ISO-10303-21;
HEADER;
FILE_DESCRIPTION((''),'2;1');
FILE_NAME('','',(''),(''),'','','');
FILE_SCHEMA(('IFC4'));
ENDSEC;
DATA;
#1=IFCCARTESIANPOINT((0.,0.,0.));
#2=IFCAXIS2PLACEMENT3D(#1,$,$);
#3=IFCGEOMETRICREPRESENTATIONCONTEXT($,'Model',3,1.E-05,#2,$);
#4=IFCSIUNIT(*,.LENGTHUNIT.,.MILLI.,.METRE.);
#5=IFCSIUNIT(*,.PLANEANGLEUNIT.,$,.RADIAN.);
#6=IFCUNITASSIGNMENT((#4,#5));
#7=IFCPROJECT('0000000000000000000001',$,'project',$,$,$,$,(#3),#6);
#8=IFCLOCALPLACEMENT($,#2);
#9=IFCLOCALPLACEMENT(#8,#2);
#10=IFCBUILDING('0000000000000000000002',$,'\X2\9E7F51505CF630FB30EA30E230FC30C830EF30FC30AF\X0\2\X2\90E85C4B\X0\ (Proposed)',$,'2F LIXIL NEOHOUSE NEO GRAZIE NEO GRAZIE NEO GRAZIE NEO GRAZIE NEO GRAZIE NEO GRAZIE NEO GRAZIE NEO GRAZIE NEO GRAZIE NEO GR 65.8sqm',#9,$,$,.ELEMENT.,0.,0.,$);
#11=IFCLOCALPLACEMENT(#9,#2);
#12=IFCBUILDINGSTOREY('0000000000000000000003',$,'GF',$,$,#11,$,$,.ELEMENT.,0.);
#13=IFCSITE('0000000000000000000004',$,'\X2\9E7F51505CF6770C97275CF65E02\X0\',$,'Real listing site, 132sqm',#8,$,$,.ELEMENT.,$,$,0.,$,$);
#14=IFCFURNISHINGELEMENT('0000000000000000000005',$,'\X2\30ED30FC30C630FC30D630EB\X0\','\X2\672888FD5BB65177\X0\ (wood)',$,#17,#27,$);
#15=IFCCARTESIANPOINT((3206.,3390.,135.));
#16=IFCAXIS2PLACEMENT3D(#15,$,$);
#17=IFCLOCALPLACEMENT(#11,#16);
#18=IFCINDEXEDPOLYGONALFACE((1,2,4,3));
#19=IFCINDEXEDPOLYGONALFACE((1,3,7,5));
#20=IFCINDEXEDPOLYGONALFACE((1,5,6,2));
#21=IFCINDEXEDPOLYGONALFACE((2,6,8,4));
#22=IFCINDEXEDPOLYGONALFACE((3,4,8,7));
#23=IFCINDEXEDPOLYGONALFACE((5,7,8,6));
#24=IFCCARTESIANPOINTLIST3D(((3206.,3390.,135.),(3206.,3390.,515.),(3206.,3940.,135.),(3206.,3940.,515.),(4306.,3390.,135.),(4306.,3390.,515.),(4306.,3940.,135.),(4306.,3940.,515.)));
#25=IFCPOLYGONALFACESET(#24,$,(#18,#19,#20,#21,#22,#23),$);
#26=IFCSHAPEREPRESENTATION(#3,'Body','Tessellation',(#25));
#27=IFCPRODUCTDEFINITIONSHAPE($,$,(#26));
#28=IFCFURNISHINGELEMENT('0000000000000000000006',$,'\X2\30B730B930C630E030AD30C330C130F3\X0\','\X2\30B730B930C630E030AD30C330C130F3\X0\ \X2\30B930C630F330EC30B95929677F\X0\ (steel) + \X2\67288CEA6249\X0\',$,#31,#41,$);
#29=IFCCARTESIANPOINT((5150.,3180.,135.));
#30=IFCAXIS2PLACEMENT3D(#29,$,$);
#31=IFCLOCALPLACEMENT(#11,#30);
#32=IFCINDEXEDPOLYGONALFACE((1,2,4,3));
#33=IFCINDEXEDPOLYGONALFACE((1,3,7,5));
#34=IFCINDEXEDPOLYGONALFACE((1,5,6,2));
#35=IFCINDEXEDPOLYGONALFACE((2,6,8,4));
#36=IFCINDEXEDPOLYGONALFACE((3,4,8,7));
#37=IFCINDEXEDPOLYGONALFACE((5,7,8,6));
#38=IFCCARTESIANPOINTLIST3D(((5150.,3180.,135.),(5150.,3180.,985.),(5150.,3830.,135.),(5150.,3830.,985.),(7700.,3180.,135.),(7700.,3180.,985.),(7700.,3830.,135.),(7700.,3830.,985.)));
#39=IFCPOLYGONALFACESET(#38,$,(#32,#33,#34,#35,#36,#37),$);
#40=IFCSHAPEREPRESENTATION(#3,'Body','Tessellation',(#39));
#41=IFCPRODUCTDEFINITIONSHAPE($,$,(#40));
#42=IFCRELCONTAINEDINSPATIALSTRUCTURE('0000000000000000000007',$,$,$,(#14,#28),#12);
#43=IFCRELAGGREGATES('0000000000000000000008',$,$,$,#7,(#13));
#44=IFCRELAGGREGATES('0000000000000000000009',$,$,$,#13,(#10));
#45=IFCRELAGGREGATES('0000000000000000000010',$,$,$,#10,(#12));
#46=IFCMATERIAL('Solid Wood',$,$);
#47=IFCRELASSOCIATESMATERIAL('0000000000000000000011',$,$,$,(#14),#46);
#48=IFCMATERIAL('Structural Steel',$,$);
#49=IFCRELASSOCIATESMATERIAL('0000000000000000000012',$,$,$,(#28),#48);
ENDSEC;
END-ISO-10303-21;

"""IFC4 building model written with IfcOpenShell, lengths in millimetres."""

from ifc_helpers import new_model, si_unit, frame, frame_2d, origin, place, context, project, spatial, rectangle, extrude, material, element, save


model = new_model("IFC4")

# Units and contexts
model_context = context("Model", 3, precision=1e-05, world=origin())
ifc_project = project(units=[si_unit("LENGTHUNIT", "METRE", prefix="MILLI"), si_unit("PLANEANGLEUNIT", "RADIAN")], contexts=[model_context])

# Site, building, storey
site_placement = place(None, origin())
site = spatial("IfcSite", under=ifc_project, at=site_placement, Name="鹿児島県霧島市", ObjectType="Real listing site, 132sqm", CompositionType="ELEMENT", RefElevation=0.0)
building_placement = place(site_placement, origin())
building = spatial("IfcBuilding", under=site, at=building_placement, Name="鹿児島・リモートワーク2部屋 (Proposed)", ObjectType="2F LIXIL NEOHOUSE NEO GRAZIE NEO GRAZIE NEO GRAZIE NEO GRAZIE NEO GRAZIE NEO GRAZIE NEO GRAZIE NEO GRAZIE NEO GRAZIE NEO GR 65.8sqm", CompositionType="ELEMENT", ElevationOfRefHeight=0.0, ElevationOfTerrain=0.0)
storey_placement = place(building_placement, origin())
storey = spatial("IfcBuildingStorey", under=building, at=storey_placement, Name="GF", CompositionType="ELEMENT", Elevation=0.0)

# Shared definitions
ifc_material_1 = material(Name="Solid Wood")

# Furnishing elements
furnishing_1_placement = place(storey_placement, frame((3206.0, 3390.0, 135.0)))
element("IfcFurnishingElement", 1, at=furnishing_1_placement, inside=storey, material=ifc_material_1, Name="ローテーブル", Description="木製家具 (wood)", context=model_context, shape_type="SweptSolid", body=[
    extrude(rectangle(XDim=1100.0, YDim=550.0, at=frame_2d((550.0, 275.0))), frame((3206.0, 3390.0, 135.0)), (0.0, 0.0, 1.0), 380.0),
])
ifc_material_2 = material(Name="Structural Steel")
furnishing_2_placement = place(storey_placement, frame((5150.0, 3180.0, 135.0)))
element("IfcFurnishingElement", 2, at=furnishing_2_placement, inside=storey, material=ifc_material_2, Name="システムキッチン", Description="システムキッチン ステンレス天板 (steel) + 木質扉", context=model_context, shape_type="SweptSolid", body=[
    extrude(rectangle(XDim=2550.0, YDim=650.0, at=frame_2d((1275.0, 325.0))), frame((5150.0, 3180.0, 135.0)), (0.0, 0.0, 1.0), 850.0),
])

save(model, "model.ifc")
